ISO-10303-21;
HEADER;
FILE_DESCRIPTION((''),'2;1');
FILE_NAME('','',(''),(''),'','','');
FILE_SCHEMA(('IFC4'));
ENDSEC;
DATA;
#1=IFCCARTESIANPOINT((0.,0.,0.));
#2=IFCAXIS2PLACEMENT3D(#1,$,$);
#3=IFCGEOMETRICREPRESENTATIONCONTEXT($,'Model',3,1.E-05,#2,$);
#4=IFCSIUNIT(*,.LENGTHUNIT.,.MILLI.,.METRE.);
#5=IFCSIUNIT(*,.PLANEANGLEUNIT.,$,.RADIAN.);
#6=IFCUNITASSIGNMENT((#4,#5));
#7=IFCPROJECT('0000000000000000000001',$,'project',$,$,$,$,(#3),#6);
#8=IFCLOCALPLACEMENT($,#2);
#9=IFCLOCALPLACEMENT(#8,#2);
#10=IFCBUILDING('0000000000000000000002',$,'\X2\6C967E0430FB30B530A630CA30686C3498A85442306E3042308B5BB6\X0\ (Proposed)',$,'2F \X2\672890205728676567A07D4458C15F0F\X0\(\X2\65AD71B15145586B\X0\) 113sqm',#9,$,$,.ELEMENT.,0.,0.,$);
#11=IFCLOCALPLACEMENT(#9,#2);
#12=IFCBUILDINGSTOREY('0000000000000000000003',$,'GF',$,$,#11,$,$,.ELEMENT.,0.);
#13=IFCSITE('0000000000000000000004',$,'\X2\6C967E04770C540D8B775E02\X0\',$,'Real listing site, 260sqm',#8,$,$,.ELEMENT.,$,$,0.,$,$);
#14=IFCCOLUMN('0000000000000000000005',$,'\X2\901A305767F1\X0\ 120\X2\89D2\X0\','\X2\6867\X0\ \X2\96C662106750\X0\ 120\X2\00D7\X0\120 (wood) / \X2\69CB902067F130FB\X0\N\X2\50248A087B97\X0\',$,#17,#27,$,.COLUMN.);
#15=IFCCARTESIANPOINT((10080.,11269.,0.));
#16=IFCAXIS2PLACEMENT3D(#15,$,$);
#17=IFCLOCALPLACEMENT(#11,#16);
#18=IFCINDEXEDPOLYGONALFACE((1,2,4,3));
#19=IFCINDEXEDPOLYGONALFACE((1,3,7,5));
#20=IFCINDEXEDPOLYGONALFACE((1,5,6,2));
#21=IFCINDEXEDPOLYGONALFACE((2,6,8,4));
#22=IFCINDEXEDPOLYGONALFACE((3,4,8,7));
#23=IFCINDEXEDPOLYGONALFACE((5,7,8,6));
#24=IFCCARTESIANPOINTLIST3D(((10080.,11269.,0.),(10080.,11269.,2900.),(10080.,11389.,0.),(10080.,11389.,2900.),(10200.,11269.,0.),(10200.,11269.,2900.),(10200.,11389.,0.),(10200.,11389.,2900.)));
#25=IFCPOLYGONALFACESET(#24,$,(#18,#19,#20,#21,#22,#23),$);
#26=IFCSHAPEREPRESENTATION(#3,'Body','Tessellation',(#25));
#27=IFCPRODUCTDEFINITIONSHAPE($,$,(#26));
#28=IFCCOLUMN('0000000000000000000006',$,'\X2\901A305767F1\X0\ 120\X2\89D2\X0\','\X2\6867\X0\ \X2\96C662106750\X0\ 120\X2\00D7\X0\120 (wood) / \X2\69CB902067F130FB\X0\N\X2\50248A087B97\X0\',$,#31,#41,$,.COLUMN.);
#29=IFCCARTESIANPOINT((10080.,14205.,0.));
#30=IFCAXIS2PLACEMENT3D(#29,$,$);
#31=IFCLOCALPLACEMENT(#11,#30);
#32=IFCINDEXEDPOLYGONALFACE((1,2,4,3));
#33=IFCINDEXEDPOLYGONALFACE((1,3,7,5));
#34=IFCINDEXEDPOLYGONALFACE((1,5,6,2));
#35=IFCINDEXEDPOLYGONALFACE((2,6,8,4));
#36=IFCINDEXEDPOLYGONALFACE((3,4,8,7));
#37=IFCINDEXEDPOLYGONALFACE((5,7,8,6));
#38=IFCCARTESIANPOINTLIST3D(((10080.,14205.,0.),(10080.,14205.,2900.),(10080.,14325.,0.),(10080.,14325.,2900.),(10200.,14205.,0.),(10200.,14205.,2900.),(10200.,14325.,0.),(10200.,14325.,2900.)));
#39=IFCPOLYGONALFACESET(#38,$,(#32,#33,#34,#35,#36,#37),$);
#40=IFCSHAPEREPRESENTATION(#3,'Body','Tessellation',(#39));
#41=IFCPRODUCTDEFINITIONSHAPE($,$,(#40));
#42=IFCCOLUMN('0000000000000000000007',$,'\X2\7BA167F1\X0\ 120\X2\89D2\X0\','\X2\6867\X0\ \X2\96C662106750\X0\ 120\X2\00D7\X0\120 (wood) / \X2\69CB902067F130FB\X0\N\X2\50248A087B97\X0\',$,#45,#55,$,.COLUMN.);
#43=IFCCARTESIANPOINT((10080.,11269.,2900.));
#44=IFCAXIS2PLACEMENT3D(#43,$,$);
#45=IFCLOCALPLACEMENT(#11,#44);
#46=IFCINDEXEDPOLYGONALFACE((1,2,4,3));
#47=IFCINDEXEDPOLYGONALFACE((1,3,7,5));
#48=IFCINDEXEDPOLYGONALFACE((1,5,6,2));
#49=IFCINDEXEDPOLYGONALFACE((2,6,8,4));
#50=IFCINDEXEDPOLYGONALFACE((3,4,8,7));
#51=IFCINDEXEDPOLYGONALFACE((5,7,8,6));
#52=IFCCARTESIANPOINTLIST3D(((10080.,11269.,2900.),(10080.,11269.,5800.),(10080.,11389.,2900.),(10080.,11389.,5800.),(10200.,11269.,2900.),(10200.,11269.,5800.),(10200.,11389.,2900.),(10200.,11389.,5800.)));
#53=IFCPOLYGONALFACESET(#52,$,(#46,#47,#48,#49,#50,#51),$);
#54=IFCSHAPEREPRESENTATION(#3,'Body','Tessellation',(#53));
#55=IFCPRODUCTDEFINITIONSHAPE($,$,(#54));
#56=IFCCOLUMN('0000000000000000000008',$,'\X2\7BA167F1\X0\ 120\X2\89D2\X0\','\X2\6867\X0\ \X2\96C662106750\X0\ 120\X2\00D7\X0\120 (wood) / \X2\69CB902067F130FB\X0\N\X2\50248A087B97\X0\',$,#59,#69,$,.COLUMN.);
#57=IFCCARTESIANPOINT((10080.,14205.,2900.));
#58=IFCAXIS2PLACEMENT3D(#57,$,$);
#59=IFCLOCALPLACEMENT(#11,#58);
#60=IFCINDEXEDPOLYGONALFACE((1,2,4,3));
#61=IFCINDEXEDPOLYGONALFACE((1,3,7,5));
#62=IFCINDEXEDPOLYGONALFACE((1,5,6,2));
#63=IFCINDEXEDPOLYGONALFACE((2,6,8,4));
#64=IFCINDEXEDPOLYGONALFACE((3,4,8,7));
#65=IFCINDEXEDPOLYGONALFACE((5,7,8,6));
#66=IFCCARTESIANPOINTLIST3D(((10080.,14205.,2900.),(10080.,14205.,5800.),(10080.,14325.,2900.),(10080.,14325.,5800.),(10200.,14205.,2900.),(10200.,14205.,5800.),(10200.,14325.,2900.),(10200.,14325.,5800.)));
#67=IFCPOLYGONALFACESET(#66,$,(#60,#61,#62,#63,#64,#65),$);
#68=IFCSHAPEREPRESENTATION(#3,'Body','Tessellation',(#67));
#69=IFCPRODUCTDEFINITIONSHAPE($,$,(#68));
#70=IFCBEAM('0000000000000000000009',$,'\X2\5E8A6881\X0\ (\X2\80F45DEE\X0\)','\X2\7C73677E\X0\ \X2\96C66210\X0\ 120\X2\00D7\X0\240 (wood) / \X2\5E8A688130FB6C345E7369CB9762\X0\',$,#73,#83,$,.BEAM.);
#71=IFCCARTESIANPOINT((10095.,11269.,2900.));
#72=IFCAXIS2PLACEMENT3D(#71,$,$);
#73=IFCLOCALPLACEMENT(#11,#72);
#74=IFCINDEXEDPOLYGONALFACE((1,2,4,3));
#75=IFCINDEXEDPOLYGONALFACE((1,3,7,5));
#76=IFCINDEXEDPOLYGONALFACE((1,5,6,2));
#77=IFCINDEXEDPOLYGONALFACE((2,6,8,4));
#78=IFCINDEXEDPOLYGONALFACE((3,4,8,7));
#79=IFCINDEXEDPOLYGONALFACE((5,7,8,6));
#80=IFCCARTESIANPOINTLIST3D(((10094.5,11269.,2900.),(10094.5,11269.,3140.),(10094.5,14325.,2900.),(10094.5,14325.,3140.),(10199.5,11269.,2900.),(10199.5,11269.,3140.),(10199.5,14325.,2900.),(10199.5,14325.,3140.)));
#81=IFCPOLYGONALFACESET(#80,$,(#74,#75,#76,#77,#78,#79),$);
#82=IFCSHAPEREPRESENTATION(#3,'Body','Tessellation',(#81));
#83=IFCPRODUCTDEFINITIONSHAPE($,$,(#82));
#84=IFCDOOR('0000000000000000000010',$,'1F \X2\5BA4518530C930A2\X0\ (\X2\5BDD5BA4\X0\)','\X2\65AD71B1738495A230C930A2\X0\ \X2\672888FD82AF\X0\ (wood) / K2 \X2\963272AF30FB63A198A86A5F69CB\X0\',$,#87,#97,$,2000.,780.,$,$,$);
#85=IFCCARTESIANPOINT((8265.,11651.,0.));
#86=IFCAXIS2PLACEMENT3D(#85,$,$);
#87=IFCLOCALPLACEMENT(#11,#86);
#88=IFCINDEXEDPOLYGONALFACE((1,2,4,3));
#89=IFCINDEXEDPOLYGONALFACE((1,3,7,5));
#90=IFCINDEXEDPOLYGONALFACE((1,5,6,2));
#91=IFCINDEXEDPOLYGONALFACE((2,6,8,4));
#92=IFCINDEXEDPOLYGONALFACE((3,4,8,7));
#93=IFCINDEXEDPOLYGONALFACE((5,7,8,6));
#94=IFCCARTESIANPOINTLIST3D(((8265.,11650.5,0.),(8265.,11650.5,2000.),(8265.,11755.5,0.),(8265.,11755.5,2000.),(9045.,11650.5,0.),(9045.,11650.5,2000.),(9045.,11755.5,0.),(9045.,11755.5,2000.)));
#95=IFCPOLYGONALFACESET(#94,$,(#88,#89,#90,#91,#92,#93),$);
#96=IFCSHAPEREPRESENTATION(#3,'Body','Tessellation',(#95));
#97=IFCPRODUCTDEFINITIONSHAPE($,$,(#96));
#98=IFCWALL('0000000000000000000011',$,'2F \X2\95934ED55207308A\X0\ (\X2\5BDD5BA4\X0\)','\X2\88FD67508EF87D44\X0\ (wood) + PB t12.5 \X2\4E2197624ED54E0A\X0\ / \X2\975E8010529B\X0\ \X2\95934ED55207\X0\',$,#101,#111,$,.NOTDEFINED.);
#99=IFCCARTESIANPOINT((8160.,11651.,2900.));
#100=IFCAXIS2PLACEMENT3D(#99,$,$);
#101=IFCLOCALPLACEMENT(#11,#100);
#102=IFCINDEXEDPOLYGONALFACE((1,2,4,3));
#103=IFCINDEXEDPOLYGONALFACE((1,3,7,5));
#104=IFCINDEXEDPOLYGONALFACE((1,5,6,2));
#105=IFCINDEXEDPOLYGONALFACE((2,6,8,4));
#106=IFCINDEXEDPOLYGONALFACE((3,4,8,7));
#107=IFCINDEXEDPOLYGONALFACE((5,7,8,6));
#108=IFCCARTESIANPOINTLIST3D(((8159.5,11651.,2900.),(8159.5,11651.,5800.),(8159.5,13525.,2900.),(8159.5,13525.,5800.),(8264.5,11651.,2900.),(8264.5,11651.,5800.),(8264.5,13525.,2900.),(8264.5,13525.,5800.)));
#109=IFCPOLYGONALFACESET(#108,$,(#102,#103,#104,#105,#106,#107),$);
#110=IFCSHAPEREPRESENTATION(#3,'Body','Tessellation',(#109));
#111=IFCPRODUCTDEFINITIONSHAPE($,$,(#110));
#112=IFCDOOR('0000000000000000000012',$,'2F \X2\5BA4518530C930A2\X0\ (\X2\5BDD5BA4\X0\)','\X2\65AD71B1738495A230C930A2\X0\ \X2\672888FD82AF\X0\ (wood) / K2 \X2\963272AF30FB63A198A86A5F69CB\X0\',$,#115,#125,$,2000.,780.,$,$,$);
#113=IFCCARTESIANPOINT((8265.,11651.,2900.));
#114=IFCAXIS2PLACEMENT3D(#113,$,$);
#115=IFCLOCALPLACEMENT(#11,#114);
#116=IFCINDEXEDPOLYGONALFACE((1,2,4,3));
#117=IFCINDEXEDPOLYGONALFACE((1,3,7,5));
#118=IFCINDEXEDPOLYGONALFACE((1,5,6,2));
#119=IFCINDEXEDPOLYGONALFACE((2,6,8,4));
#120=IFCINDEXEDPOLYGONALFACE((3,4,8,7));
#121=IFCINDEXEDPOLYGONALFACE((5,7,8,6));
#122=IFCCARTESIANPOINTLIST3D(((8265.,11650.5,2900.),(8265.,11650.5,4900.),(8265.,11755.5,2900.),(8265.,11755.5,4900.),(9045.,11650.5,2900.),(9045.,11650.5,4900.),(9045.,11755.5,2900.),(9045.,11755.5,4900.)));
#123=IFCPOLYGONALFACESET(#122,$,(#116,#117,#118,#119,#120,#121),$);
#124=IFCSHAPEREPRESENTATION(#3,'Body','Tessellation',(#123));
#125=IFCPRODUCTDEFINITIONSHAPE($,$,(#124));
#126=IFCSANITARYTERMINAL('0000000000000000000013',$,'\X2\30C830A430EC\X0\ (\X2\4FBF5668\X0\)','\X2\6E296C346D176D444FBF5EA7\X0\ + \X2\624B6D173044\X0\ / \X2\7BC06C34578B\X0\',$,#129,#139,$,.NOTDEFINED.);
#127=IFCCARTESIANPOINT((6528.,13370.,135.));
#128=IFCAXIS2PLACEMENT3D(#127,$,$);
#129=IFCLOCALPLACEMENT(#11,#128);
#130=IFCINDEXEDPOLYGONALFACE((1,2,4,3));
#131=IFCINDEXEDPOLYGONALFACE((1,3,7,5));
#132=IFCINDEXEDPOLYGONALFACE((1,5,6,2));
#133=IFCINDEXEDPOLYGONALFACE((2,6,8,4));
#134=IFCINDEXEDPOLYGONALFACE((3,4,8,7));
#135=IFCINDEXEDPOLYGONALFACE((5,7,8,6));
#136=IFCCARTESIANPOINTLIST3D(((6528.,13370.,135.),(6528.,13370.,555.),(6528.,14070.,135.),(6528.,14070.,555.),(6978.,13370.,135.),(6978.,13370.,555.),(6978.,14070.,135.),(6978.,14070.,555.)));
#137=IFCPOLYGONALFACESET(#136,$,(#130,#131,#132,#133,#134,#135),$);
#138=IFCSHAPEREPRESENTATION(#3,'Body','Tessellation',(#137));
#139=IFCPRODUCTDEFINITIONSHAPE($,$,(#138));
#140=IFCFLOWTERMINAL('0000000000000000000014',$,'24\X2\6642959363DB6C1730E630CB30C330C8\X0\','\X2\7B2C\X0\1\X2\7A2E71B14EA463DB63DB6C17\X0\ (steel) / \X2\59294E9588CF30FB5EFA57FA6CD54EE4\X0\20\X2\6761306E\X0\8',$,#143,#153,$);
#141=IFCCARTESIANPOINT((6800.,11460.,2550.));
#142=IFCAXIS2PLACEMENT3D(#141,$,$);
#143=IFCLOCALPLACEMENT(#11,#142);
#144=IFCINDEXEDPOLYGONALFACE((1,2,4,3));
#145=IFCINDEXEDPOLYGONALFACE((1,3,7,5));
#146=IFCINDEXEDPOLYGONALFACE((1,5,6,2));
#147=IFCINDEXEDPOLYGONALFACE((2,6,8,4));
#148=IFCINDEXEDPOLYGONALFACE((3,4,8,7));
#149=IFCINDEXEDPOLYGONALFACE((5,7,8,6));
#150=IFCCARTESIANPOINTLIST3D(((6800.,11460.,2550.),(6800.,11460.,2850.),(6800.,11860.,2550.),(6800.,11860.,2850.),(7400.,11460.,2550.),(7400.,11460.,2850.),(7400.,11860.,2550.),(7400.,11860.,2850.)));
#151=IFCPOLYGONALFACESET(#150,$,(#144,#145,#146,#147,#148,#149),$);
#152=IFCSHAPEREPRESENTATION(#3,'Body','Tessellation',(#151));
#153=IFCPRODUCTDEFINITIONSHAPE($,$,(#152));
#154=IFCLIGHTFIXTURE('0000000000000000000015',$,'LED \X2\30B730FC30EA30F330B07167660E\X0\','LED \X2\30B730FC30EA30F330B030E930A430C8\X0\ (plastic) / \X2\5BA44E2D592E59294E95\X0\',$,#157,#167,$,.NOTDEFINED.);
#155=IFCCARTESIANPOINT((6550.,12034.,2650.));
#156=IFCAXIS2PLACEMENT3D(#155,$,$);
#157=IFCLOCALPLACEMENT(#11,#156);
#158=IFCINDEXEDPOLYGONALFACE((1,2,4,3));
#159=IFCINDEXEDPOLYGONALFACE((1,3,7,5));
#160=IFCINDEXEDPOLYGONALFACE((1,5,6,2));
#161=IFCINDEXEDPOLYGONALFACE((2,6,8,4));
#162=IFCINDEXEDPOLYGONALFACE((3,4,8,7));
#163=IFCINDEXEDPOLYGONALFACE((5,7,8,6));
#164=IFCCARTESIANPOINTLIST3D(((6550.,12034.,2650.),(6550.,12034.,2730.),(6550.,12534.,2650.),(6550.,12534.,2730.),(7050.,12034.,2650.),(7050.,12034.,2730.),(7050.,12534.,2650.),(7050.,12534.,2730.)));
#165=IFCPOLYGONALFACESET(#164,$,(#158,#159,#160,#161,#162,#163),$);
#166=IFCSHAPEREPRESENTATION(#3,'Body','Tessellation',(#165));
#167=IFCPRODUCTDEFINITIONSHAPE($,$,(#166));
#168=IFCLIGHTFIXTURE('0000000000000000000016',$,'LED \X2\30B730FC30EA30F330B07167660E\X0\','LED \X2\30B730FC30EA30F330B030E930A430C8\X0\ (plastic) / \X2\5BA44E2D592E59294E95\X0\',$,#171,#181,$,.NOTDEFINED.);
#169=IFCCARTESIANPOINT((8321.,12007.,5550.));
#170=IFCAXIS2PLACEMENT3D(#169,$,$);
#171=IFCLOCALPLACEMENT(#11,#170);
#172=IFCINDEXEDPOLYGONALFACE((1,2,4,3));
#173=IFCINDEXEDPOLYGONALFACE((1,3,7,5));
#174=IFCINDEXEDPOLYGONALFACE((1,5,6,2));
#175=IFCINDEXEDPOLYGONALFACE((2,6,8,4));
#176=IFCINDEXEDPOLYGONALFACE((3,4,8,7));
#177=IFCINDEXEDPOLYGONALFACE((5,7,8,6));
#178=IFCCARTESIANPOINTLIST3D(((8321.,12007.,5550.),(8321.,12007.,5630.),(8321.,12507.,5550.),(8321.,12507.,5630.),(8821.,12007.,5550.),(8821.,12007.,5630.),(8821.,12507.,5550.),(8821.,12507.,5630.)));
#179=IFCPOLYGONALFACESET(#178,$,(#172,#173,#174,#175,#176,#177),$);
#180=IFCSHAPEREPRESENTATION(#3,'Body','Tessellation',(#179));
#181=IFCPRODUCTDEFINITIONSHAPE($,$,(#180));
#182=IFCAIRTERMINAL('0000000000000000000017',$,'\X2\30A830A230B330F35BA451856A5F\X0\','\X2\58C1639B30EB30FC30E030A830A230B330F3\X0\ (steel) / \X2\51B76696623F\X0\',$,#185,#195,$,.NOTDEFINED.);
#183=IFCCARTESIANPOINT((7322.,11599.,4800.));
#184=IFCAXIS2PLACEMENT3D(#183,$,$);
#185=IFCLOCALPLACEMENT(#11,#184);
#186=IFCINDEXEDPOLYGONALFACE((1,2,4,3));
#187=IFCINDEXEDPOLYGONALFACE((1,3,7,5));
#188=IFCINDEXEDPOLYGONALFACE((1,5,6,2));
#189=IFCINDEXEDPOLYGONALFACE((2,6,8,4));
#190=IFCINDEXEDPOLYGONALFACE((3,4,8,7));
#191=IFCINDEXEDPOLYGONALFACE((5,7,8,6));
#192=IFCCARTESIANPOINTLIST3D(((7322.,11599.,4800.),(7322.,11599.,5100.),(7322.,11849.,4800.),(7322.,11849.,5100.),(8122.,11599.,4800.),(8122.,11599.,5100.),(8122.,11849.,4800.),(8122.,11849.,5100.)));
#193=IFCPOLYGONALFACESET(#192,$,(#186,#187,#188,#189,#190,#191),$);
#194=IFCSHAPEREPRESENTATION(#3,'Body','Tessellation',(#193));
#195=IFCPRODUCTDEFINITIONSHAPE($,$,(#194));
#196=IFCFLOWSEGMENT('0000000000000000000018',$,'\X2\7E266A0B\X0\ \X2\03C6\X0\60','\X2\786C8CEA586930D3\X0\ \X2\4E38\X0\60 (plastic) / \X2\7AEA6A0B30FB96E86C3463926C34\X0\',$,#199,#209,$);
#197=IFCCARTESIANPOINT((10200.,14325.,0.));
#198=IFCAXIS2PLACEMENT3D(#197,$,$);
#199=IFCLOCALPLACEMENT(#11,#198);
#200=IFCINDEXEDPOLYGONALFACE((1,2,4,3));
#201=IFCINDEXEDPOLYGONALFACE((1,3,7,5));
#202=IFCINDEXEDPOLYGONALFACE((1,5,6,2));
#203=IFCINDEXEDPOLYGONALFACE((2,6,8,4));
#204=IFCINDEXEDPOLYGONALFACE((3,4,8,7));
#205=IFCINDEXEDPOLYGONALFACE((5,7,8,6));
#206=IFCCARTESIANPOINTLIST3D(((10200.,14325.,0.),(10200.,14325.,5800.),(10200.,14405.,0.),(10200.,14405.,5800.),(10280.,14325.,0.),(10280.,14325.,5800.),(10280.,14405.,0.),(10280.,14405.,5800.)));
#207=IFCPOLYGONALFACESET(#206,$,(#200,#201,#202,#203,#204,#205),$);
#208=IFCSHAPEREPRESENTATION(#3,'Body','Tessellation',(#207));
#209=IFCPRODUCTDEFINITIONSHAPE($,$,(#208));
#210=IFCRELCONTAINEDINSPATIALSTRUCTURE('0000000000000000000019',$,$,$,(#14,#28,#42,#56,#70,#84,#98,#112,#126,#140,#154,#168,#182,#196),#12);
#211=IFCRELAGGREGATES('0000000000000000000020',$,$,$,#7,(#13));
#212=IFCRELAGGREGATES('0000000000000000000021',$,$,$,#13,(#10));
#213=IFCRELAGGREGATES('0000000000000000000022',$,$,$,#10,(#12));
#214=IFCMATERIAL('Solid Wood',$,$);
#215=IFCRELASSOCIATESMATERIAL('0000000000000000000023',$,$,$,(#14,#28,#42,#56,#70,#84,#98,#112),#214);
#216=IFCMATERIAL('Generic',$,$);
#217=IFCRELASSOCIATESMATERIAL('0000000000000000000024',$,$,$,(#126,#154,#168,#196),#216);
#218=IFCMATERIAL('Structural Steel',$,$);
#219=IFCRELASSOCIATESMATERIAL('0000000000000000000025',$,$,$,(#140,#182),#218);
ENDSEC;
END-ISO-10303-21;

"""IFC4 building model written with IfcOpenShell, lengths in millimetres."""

from ifc_helpers import new_model, si_unit, frame, frame_2d, origin, place, context, project, spatial, rectangle, extrude, material, element, save


model = new_model("IFC4")

# Units and contexts
model_context = context("Model", 3, precision=1e-05, world=origin())
ifc_project = project(units=[si_unit("LENGTHUNIT", "METRE", prefix="MILLI"), si_unit("PLANEANGLEUNIT", "RADIAN")], contexts=[model_context])

# Site, building, storey
site_placement = place(None, origin())
site = spatial("IfcSite", under=ifc_project, at=site_placement, Name="沖縄県名護市", ObjectType="Real listing site, 260sqm", CompositionType="ELEMENT", RefElevation=0.0)
building_placement = place(site_placement, origin())
building = spatial("IfcBuilding", under=site, at=building_placement, Name="沖縄・サウナと水風呂のある家 (Proposed)", ObjectType="2F 木造在来枠組壁式(断熱充填) 113sqm", CompositionType="ELEMENT", ElevationOfRefHeight=0.0, ElevationOfTerrain=0.0)
storey_placement = place(building_placement, origin())
storey = spatial("IfcBuildingStorey", under=building, at=storey_placement, Name="GF", CompositionType="ELEMENT", Elevation=0.0)

# Columns
ifc_material_1 = material(Name="Solid Wood")
column_1_placement = place(storey_placement, frame((10080.0, 11269.0, 0.0)))
element("IfcColumn", 1, at=column_1_placement, inside=storey, material=ifc_material_1, Name="通し柱 120角", Description="桧 集成材 120×120 (wood) / 構造柱・N値計算", PredefinedType="COLUMN", context=model_context, shape_type="SweptSolid", body=[
    extrude(rectangle(XDim=120.0, YDim=120.0, at=frame_2d((60.0, 60.0))), frame((10080.0, 11269.0, 0.0)), (0.0, 0.0, 1.0), 2900.0),
])
column_2_placement = place(storey_placement, frame((10080.0, 14205.0, 0.0)))
element("IfcColumn", 2, at=column_2_placement, inside=storey, material=ifc_material_1, Name="通し柱 120角", Description="桧 集成材 120×120 (wood) / 構造柱・N値計算", PredefinedType="COLUMN", context=model_context, shape_type="SweptSolid", body=[
    extrude(rectangle(XDim=120.0, YDim=120.0, at=frame_2d((60.0, 60.0))), frame((10080.0, 14205.0, 0.0)), (0.0, 0.0, 1.0), 2900.0),
])
column_3_placement = place(storey_placement, frame((10080.0, 11269.0, 2900.0)))
element("IfcColumn", 3, at=column_3_placement, inside=storey, material=ifc_material_1, Name="管柱 120角", Description="桧 集成材 120×120 (wood) / 構造柱・N値計算", PredefinedType="COLUMN", context=model_context, shape_type="SweptSolid", body=[
    extrude(rectangle(XDim=120.0, YDim=120.0, at=frame_2d((60.0, 60.0))), frame((10080.0, 11269.0, 2900.0)), (0.0, 0.0, 1.0), 2900.0),
])
column_4_placement = place(storey_placement, frame((10080.0, 14205.0, 2900.0)))
element("IfcColumn", 4, at=column_4_placement, inside=storey, material=ifc_material_1, Name="管柱 120角", Description="桧 集成材 120×120 (wood) / 構造柱・N値計算", PredefinedType="COLUMN", context=model_context, shape_type="SweptSolid", body=[
    extrude(rectangle(XDim=120.0, YDim=120.0, at=frame_2d((60.0, 60.0))), frame((10080.0, 14205.0, 2900.0)), (0.0, 0.0, 1.0), 2900.0),
])

# Beam
beam_1_placement = place(storey_placement, frame((10095.0, 11269.0, 2900.0)))
element("IfcBeam", 5, at=beam_1_placement, inside=storey, material=ifc_material_1, Name="床梁 (胴差)", Description="米松 集成 120×240 (wood) / 床梁・水平構面", PredefinedType="BEAM", context=model_context, shape_type="SweptSolid", body=[
    extrude(rectangle(XDim=105.0, YDim=3056.0, at=frame_2d((52.0, 1528.0))), frame((10095.0, 11269.0, 2900.0)), (0.0, 0.0, 1.0), 240.0),
])

# Door
door_1_placement = place(storey_placement, frame((8265.0, 11651.0, 0.0)))
element("IfcDoor", 6, at=door_1_placement, inside=storey, material=ifc_material_1, Name="1F 室内ドア (寝室)", Description="断熱玄関ドア 木製芯 (wood) / K2 防犯・採風機構", OverallHeight=2000.0, OverallWidth=780.0, context=model_context, shape_type="SweptSolid", body=[
    extrude(rectangle(XDim=780.0, YDim=105.0, at=frame_2d((390.0, 52.0))), frame((8265.0, 11651.0, 0.0)), (0.0, 0.0, 1.0), 2000.0),
])

# Wall
wall_1_placement = place(storey_placement, frame((8160.0, 11651.0, 2900.0)))
element("IfcWall", 7, at=wall_1_placement, inside=storey, material=ifc_material_1, Name="2F 間仕切り (寝室)", Description="製材軸組 (wood) + PB t12.5 両面仕上 / 非耐力 間仕切", PredefinedType="NOTDEFINED", context=model_context, shape_type="SweptSolid", body=[
    extrude(rectangle(XDim=105.0, YDim=1874.0, at=frame_2d((52.0, 937.0))), frame((8160.0, 11651.0, 2900.0)), (0.0, 0.0, 1.0), 2900.0),
])

# Door
door_2_placement = place(storey_placement, frame((8265.0, 11651.0, 2900.0)))
element("IfcDoor", 8, at=door_2_placement, inside=storey, material=ifc_material_1, Name="2F 室内ドア (寝室)", Description="断熱玄関ドア 木製芯 (wood) / K2 防犯・採風機構", OverallHeight=2000.0, OverallWidth=780.0, context=model_context, shape_type="SweptSolid", body=[
    extrude(rectangle(XDim=780.0, YDim=105.0, at=frame_2d((390.0, 52.0))), frame((8265.0, 11651.0, 2900.0)), (0.0, 0.0, 1.0), 2000.0),
])

# Sanitary terminal
ifc_material_2 = material(Name="Generic")
sanitary_terminal_placement = place(storey_placement, frame((6528.0, 13370.0, 135.0)))
element("IfcSanitaryTerminal", 9, at=sanitary_terminal_placement, inside=storey, material=ifc_material_2, Name="トイレ (便器)", Description="温水洗浄便座 + 手洗い / 節水型", PredefinedType="NOTDEFINED", context=model_context, shape_type="SweptSolid", body=[
    extrude(rectangle(XDim=450.0, YDim=700.0, at=frame_2d((225.0, 350.0))), frame((6528.0, 13370.0, 135.0)), (0.0, 0.0, 1.0), 420.0),
])

# Flow terminal
ifc_material_3 = material(Name="Structural Steel")
flow_terminal_placement = place(storey_placement, frame((6800.0, 11460.0, 2550.0)))
element("IfcFlowTerminal", 10, at=flow_terminal_placement, inside=storey, material=ifc_material_3, Name="24時間換気ユニット", Description="第1種熱交換換気 (steel) / 天井裏・建基法令20条の8", context=model_context, shape_type="SweptSolid", body=[
    extrude(rectangle(XDim=600.0, YDim=400.0, at=frame_2d((300.0, 200.0))), frame((6800.0, 11460.0, 2550.0)), (0.0, 0.0, 1.0), 300.0),
])

# Light fixtures
light_fixture_1_placement = place(storey_placement, frame((6550.0, 12034.0, 2650.0)))
element("IfcLightFixture", 11, at=light_fixture_1_placement, inside=storey, material=ifc_material_2, Name="LED シーリング照明", Description="LED シーリングライト (plastic) / 室中央天井", PredefinedType="NOTDEFINED", context=model_context, shape_type="SweptSolid", body=[
    extrude(rectangle(XDim=500.0, YDim=500.0, at=frame_2d((250.0, 250.0))), frame((6550.0, 12034.0, 2650.0)), (0.0, 0.0, 1.0), 80.0),
])
light_fixture_2_placement = place(storey_placement, frame((8321.0, 12007.0, 5550.0)))
element("IfcLightFixture", 12, at=light_fixture_2_placement, inside=storey, material=ifc_material_2, Name="LED シーリング照明", Description="LED シーリングライト (plastic) / 室中央天井", PredefinedType="NOTDEFINED", context=model_context, shape_type="SweptSolid", body=[
    extrude(rectangle(XDim=500.0, YDim=500.0, at=frame_2d((250.0, 250.0))), frame((8321.0, 12007.0, 5550.0)), (0.0, 0.0, 1.0), 80.0),
])

# Air terminal
air_terminal_placement = place(storey_placement, frame((7322.0, 11599.0, 4800.0)))
element("IfcAirTerminal", 13, at=air_terminal_placement, inside=storey, material=ifc_material_3, Name="エアコン室内機", Description="壁掛ルームエアコン (steel) / 冷暖房", PredefinedType="NOTDEFINED", context=model_context, shape_type="SweptSolid", body=[
    extrude(rectangle(XDim=800.0, YDim=250.0, at=frame_2d((400.0, 125.0))), frame((7322.0, 11599.0, 4800.0)), (0.0, 0.0, 1.0), 300.0),
])

# Flow segment
flow_segment_placement = place(storey_placement, frame((10200.0, 14325.0, 0.0)))
element("IfcFlowSegment", 14, at=flow_segment_placement, inside=storey, material=ifc_material_2, Name="縦樋 φ60", Description="硬質塩ビ 丸60 (plastic) / 竪樋・雨水排水", context=model_context, shape_type="SweptSolid", body=[
    extrude(rectangle(XDim=80.0, YDim=80.0, at=frame_2d((40.0, 40.0))), frame((10200.0, 14325.0, 0.0)), (0.0, 0.0, 1.0), 5800.0),
])

save(model, "model.ifc")
